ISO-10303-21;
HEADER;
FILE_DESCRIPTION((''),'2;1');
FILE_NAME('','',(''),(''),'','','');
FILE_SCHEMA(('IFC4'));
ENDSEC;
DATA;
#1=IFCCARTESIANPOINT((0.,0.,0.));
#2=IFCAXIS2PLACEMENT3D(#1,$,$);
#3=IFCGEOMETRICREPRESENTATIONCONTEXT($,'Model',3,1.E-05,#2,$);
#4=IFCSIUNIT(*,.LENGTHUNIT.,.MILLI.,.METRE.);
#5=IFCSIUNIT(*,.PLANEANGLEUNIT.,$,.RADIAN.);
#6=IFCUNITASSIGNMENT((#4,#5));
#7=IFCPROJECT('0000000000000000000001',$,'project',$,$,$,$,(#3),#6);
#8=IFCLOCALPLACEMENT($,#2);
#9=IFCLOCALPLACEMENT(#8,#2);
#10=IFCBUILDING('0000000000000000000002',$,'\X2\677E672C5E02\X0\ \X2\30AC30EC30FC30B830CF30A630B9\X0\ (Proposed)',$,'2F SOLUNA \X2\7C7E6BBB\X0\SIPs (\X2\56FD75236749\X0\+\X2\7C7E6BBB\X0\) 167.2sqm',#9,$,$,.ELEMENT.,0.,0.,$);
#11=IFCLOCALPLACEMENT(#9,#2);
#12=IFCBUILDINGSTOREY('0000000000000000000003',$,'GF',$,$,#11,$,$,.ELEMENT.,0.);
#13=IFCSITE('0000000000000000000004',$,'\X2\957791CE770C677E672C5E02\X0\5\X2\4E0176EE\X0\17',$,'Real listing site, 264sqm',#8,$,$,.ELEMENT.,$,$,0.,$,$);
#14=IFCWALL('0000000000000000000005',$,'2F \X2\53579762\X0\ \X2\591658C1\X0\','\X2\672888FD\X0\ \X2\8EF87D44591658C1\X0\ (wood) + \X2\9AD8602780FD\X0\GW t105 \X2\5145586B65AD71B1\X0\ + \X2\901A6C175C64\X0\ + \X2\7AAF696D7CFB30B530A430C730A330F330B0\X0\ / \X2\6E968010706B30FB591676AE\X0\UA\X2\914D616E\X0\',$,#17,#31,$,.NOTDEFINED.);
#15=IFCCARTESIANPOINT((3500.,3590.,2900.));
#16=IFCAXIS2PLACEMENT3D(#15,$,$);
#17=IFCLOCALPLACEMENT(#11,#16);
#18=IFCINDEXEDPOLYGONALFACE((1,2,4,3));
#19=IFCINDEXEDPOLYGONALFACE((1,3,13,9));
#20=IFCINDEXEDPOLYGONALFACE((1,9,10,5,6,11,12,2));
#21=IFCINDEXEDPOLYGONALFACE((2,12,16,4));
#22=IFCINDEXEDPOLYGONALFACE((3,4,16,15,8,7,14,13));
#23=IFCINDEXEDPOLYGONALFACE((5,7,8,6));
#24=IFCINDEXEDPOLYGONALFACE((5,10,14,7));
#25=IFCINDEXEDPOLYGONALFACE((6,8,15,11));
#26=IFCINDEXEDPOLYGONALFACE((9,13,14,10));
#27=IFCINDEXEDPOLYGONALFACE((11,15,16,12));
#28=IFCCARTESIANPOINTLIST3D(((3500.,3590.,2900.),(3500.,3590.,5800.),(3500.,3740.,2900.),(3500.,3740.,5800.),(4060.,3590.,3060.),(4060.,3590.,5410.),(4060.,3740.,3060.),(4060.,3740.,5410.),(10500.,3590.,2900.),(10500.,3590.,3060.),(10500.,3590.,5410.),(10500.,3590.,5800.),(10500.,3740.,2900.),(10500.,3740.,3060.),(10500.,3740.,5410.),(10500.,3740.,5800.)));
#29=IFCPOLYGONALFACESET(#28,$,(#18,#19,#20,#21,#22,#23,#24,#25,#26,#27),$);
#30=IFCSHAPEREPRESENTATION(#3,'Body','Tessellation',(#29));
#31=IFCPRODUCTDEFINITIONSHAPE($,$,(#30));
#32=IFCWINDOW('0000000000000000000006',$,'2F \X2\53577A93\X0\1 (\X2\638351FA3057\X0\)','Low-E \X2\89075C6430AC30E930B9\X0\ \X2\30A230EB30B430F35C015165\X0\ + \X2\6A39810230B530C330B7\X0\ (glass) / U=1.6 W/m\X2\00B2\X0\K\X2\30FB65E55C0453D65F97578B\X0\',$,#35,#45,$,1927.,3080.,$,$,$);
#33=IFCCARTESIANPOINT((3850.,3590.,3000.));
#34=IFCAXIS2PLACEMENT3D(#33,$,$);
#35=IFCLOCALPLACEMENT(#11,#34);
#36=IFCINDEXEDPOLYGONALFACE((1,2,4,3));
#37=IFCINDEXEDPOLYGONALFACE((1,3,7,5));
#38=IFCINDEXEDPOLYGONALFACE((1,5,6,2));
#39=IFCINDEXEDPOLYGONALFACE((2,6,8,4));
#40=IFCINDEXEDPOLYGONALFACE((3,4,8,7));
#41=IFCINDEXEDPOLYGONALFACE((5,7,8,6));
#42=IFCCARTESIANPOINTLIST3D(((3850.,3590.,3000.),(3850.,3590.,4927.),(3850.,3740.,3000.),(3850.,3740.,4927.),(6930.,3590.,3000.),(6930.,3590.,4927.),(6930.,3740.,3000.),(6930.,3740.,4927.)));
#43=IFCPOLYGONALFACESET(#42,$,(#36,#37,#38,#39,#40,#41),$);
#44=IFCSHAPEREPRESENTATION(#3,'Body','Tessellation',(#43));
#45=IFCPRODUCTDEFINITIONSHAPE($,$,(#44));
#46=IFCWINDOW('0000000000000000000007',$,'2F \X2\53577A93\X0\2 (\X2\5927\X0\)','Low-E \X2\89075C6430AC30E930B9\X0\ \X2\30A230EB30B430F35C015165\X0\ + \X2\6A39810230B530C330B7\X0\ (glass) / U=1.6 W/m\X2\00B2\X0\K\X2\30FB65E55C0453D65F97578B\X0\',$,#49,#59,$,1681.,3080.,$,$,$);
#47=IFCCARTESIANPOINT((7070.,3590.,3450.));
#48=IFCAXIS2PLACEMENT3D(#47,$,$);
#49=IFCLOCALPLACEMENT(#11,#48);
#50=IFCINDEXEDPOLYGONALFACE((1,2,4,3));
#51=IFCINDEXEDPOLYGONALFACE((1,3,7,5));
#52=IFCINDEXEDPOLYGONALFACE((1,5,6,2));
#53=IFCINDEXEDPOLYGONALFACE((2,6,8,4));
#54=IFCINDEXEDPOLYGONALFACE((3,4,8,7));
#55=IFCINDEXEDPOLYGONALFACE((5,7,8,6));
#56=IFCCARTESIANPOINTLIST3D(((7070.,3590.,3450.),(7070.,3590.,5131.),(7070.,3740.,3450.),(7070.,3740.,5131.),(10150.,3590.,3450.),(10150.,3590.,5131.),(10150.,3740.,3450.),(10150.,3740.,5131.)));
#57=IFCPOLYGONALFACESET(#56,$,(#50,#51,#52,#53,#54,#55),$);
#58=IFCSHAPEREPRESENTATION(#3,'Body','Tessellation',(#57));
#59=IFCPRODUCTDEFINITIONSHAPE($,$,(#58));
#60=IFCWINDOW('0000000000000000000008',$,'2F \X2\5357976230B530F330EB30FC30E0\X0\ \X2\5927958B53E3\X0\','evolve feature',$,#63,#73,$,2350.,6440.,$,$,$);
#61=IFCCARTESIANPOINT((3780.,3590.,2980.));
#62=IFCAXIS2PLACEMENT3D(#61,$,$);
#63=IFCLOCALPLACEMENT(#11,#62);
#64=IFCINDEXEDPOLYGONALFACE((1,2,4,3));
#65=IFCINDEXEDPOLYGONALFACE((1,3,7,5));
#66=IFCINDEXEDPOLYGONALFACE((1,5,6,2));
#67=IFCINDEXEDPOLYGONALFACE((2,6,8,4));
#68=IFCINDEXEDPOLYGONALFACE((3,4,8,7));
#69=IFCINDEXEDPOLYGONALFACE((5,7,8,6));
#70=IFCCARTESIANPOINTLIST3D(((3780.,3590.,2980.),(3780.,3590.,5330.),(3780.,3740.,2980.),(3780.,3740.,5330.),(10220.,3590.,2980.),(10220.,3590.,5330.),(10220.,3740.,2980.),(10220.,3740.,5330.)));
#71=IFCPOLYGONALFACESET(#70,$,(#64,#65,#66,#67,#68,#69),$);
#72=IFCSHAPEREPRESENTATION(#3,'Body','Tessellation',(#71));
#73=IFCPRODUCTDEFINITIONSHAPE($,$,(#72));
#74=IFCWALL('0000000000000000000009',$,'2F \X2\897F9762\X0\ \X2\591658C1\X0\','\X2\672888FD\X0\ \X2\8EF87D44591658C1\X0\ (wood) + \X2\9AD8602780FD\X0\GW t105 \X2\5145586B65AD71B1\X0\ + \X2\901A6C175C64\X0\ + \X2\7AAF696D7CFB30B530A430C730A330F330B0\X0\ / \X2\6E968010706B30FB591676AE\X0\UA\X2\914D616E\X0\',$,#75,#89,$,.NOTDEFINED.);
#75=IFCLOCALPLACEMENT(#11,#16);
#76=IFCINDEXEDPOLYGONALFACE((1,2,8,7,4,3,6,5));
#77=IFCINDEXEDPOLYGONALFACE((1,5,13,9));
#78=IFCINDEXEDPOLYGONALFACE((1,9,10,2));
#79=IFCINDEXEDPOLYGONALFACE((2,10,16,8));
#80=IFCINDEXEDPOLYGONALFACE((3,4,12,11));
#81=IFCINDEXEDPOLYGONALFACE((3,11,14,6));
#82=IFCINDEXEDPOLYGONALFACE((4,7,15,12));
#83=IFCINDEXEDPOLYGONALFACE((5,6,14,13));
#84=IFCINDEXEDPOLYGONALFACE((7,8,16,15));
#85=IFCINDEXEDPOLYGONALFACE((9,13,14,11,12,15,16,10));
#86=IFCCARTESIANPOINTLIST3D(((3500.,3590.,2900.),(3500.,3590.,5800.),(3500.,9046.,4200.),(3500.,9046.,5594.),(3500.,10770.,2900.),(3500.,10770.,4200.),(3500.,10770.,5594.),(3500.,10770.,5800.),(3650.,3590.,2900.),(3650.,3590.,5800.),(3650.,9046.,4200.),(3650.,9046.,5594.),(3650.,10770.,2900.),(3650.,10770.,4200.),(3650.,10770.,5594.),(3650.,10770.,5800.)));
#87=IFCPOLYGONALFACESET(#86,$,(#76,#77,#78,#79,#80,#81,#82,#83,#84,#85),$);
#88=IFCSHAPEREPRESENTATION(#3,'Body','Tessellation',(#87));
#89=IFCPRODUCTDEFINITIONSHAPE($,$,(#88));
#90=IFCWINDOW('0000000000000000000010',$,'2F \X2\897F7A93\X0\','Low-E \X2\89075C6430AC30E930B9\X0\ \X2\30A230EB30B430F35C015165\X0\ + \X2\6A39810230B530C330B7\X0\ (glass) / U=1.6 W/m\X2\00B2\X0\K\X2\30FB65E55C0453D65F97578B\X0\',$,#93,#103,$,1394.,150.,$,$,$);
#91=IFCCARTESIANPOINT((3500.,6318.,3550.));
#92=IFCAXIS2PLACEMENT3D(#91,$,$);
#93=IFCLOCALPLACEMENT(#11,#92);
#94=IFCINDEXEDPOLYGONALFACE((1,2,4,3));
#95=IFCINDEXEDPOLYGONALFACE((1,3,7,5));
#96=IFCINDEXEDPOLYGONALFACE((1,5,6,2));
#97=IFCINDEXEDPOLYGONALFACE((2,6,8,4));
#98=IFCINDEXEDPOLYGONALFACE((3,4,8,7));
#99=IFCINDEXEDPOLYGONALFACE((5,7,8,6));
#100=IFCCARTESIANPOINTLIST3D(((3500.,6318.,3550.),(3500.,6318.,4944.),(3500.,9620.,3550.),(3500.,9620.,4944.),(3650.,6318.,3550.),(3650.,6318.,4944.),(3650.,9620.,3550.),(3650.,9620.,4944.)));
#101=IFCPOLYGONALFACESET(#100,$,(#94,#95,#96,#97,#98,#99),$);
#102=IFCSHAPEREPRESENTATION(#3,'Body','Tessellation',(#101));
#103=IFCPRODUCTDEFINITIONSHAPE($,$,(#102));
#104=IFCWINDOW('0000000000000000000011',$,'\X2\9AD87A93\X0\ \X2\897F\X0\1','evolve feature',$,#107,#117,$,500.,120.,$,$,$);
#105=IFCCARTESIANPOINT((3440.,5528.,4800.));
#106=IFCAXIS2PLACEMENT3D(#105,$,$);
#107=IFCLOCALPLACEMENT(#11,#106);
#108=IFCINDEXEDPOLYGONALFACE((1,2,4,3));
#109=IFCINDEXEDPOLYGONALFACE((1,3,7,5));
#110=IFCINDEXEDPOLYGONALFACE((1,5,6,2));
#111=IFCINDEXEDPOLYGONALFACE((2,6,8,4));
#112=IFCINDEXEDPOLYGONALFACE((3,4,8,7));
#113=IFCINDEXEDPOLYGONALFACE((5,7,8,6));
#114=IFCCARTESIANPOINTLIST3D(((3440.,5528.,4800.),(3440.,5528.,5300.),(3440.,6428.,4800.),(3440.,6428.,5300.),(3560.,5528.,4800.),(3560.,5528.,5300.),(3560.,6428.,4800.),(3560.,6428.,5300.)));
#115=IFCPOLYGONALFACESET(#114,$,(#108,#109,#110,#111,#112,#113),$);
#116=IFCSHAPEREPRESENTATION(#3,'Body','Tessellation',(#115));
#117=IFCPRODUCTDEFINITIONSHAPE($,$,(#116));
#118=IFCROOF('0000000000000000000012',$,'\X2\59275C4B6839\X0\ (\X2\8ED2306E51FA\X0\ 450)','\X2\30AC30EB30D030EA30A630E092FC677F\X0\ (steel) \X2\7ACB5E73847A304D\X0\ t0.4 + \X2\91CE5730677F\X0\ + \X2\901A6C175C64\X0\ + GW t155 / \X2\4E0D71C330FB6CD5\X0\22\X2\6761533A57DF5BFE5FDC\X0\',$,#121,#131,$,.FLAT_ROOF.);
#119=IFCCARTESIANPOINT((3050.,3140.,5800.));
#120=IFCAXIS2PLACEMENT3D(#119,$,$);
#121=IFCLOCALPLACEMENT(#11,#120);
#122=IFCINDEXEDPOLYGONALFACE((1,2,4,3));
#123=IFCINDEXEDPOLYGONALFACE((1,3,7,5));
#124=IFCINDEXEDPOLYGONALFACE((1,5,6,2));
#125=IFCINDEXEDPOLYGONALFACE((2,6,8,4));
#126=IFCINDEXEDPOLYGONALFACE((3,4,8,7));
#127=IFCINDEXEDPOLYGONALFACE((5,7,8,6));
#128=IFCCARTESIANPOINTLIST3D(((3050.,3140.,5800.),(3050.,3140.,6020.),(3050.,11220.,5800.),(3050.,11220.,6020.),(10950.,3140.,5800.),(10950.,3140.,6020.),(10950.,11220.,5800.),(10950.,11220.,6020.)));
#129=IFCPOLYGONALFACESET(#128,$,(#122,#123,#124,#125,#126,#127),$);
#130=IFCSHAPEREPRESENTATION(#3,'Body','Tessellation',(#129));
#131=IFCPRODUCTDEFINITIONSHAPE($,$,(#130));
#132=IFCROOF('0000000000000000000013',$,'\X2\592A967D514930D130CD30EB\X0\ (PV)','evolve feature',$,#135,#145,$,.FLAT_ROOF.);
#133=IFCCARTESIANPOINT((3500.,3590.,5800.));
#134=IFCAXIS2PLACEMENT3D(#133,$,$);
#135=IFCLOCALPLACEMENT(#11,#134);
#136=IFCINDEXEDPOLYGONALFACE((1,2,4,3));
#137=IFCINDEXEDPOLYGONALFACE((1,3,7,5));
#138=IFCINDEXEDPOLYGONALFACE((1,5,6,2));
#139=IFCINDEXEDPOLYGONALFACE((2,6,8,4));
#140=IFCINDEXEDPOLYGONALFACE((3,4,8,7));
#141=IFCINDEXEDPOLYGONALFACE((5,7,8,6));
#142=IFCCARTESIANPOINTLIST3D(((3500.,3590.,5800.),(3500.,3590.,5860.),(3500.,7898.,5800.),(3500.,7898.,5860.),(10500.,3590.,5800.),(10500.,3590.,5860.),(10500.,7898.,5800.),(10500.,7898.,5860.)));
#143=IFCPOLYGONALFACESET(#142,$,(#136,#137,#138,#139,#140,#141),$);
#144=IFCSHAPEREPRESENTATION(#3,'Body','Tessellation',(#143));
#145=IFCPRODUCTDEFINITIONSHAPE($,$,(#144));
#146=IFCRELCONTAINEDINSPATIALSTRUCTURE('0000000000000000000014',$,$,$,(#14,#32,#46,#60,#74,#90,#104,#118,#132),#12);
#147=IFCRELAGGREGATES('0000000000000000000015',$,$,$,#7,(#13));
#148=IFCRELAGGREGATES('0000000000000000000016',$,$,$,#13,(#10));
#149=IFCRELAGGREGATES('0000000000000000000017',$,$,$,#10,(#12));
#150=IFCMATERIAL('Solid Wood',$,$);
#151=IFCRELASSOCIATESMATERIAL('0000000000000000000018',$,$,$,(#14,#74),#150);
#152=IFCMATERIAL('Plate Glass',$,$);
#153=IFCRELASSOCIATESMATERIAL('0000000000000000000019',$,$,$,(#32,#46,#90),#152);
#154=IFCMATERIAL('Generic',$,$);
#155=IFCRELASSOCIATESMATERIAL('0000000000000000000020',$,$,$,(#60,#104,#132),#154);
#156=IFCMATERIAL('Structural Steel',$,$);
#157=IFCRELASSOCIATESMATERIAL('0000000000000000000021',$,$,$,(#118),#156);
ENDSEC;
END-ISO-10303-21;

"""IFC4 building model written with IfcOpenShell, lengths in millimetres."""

from ifc_helpers import new_model, si_unit, frame, frame_2d, origin, place, context, project, spatial, rectangle, extrude, material, element, fill, save


model = new_model("IFC4")

# Units and contexts
model_context = context("Model", 3, precision=1e-05, world=origin())
ifc_project = project(units=[si_unit("LENGTHUNIT", "METRE", prefix="MILLI"), si_unit("PLANEANGLEUNIT", "RADIAN")], contexts=[model_context])

# Site, building, storey
site_placement = place(None, origin())
site = spatial("IfcSite", under=ifc_project, at=site_placement, Name="長野県松本市5丁目17", ObjectType="Real listing site, 264sqm", CompositionType="ELEMENT", RefElevation=0.0)
building_placement = place(site_placement, origin())
building = spatial("IfcBuilding", under=site, at=building_placement, Name="松本市 ガレージハウス (Proposed)", ObjectType="2F SOLUNA 籾殻SIPs (国産杉+籾殻) 167.2sqm", CompositionType="ELEMENT", ElevationOfRefHeight=0.0, ElevationOfTerrain=0.0)
storey_placement = place(building_placement, origin())
storey = spatial("IfcBuildingStorey", under=building, at=storey_placement, Name="GF", CompositionType="ELEMENT", Elevation=0.0)

# Shared definitions
ifc_material_1 = material(Name="Solid Wood")
ifc_material_2 = material(Name="Generic")

# Shared definitions
ifc_material_3 = material(Name="Plate Glass")

# Walls, openings, windows
wall_1_placement = place(storey_placement, frame((3500.0, 3590.0, 2900.0)))
wall_1 = element("IfcWall", 1, at=wall_1_placement, inside=storey, material=ifc_material_1, Name="2F 南面 外壁", Description="木製 軸組外壁 (wood) + 高性能GW t105 充填断熱 + 通気層 + 窯業系サイディング / 準耐火・外皮UA配慮", PredefinedType="NOTDEFINED", context=model_context, shape_type="SweptSolid", body=[
    extrude(rectangle(XDim=7000.0, YDim=150.0, at=frame_2d((3500.0, 75.0))), frame((3500.0, 3590.0, 2900.0)), (0.0, 0.0, 1.0), 2900.0),
])
opening_1_placement = place(storey_placement, frame((3850.0, 3590.0, 3000.0)))
opening_1 = element("IfcOpeningElement", 2, at=opening_1_placement, cuts=wall_1, PredefinedType="NOTDEFINED", context=model_context, shape_type="SweptSolid", body=[
    extrude(rectangle(XDim=3080.0, YDim=150.0, at=frame_2d((1540.0, 75.0))), frame((3850.0, 3590.0, 3000.0)), (0.0, 0.0, 1.0), 1927.0),
])
opening_2_placement = place(storey_placement, frame((7070.0, 3590.0, 3450.0)))
opening_2 = element("IfcOpeningElement", 3, at=opening_2_placement, cuts=wall_1, PredefinedType="NOTDEFINED", context=model_context, shape_type="SweptSolid", body=[
    extrude(rectangle(XDim=3080.0, YDim=150.0, at=frame_2d((1540.0, 75.0))), frame((7070.0, 3590.0, 3450.0)), (0.0, 0.0, 1.0), 1681.0),
])
opening_3_placement = place(storey_placement, frame((3780.0, 3590.0, 2980.0)))
opening_3 = element("IfcOpeningElement", 4, at=opening_3_placement, cuts=wall_1, PredefinedType="NOTDEFINED", context=model_context, shape_type="SweptSolid", body=[
    extrude(rectangle(XDim=6440.0, YDim=150.0, at=frame_2d((3220.0, 75.0))), frame((3780.0, 3590.0, 2980.0)), (0.0, 0.0, 1.0), 2350.0),
])
window_1_placement = place(storey_placement, frame((3850.0, 3590.0, 3000.0)))
window_1 = element("IfcWindow", 5, at=window_1_placement, inside=storey, material=ifc_material_3, Name="2F 南窓1 (掃出し)", Description="Low-E 複層ガラス アルゴン封入 + 樹脂サッシ (glass) / U=1.6 W/m²K・日射取得型", OverallHeight=1927.0, OverallWidth=3080.0, context=model_context, shape_type="SweptSolid", body=[
    extrude(rectangle(XDim=3080.0, YDim=150.0, at=frame_2d((1540.0, 75.0))), frame((3850.0, 3590.0, 3000.0)), (0.0, 0.0, 1.0), 1927.0),
])
fill(opening_1, window_1)
window_2_placement = place(storey_placement, frame((7070.0, 3590.0, 3450.0)))
window_2 = element("IfcWindow", 6, at=window_2_placement, inside=storey, material=ifc_material_3, Name="2F 南窓2 (大)", Description="Low-E 複層ガラス アルゴン封入 + 樹脂サッシ (glass) / U=1.6 W/m²K・日射取得型", OverallHeight=1681.0, OverallWidth=3080.0, context=model_context, shape_type="SweptSolid", body=[
    extrude(rectangle(XDim=3080.0, YDim=150.0, at=frame_2d((1540.0, 75.0))), frame((7070.0, 3590.0, 3450.0)), (0.0, 0.0, 1.0), 1681.0),
])
fill(opening_2, window_2)
window_3_placement = place(storey_placement, frame((3780.0, 3590.0, 2980.0)))
window_3 = element("IfcWindow", 7, at=window_3_placement, inside=storey, material=ifc_material_2, Name="2F 南面サンルーム 大開口", Description="evolve feature", OverallHeight=2350.0, OverallWidth=6440.0, context=model_context, shape_type="SweptSolid", body=[
    extrude(rectangle(XDim=6440.0, YDim=150.0, at=frame_2d((3220.0, 75.0))), frame((3780.0, 3590.0, 2980.0)), (0.0, 0.0, 1.0), 2350.0),
])
fill(opening_3, window_3)
wall_2_placement = place(storey_placement, frame((3500.0, 3590.0, 2900.0)))
wall_2 = element("IfcWall", 8, at=wall_2_placement, inside=storey, material=ifc_material_1, Name="2F 西面 外壁", Description="木製 軸組外壁 (wood) + 高性能GW t105 充填断熱 + 通気層 + 窯業系サイディング / 準耐火・外皮UA配慮", PredefinedType="NOTDEFINED", context=model_context, shape_type="SweptSolid", body=[
    extrude(rectangle(XDim=150.0, YDim=7180.0, at=frame_2d((75.0, 3590.0))), frame((3500.0, 3590.0, 2900.0)), (0.0, 0.0, 1.0), 2900.0),
])
opening_4_placement = place(storey_placement, frame((3500.0, 6318.0, 3550.0)))
opening_4 = element("IfcOpeningElement", 9, at=opening_4_placement, cuts=wall_2, PredefinedType="NOTDEFINED", context=model_context, shape_type="SweptSolid", body=[
    extrude(rectangle(XDim=150.0, YDim=3302.0, at=frame_2d((75.0, 1651.0))), frame((3500.0, 6318.0, 3550.0)), (0.0, 0.0, 1.0), 1394.0),
])
opening_5_placement = place(storey_placement, frame((3440.0, 5528.0, 4800.0)))
opening_5 = element("IfcOpeningElement", 10, at=opening_5_placement, cuts=wall_2, PredefinedType="NOTDEFINED", context=model_context, shape_type="SweptSolid", body=[
    extrude(rectangle(XDim=120.0, YDim=900.0, at=frame_2d((60.0, 450.0))), frame((3440.0, 5528.0, 4800.0)), (0.0, 0.0, 1.0), 500.0),
])
window_4_placement = place(storey_placement, frame((3500.0, 6318.0, 3550.0)))
window_4 = element("IfcWindow", 11, at=window_4_placement, inside=storey, material=ifc_material_3, Name="2F 西窓", Description="Low-E 複層ガラス アルゴン封入 + 樹脂サッシ (glass) / U=1.6 W/m²K・日射取得型", OverallHeight=1394.0, OverallWidth=150.0, context=model_context, shape_type="SweptSolid", body=[
    extrude(rectangle(XDim=150.0, YDim=3302.0, at=frame_2d((75.0, 1651.0))), frame((3500.0, 6318.0, 3550.0)), (0.0, 0.0, 1.0), 1394.0),
])
fill(opening_4, window_4)
window_5_placement = place(storey_placement, frame((3440.0, 5528.0, 4800.0)))
window_5 = element("IfcWindow", 12, at=window_5_placement, inside=storey, material=ifc_material_2, Name="高窓 西1", Description="evolve feature", OverallHeight=500.0, OverallWidth=120.0, context=model_context, shape_type="SweptSolid", body=[
    extrude(rectangle(XDim=120.0, YDim=900.0, at=frame_2d((60.0, 450.0))), frame((3440.0, 5528.0, 4800.0)), (0.0, 0.0, 1.0), 500.0),
])
fill(opening_5, window_5)

# Roofs
ifc_material_4 = material(Name="Structural Steel")
roof_1_placement = place(storey_placement, frame((3050.0, 3140.0, 5800.0)))
element("IfcRoof", 13, at=roof_1_placement, inside=storey, material=ifc_material_4, Name="大屋根 (軒の出 450)", Description="ガルバリウム鋼板 (steel) 立平葺き t0.4 + 野地板 + 通気層 + GW t155 / 不燃・法22条区域対応", PredefinedType="FLAT_ROOF", context=model_context, shape_type="SweptSolid", body=[
    extrude(rectangle(XDim=7900.0, YDim=8080.0, at=frame_2d((3950.0, 4040.0))), frame((3050.0, 3140.0, 5800.0)), (0.0, 0.0, 1.0), 220.0),
])
roof_2_placement = place(storey_placement, frame((3500.0, 3590.0, 5800.0)))
element("IfcRoof", 14, at=roof_2_placement, inside=storey, material=ifc_material_2, Name="太陽光パネル (PV)", Description="evolve feature", PredefinedType="FLAT_ROOF", context=model_context, shape_type="SweptSolid", body=[
    extrude(rectangle(XDim=7000.0, YDim=4308.0, at=frame_2d((3500.0, 2154.0))), frame((3500.0, 3590.0, 5800.0)), (0.0, 0.0, 1.0), 60.0),
])

save(model, "model.ifc")
